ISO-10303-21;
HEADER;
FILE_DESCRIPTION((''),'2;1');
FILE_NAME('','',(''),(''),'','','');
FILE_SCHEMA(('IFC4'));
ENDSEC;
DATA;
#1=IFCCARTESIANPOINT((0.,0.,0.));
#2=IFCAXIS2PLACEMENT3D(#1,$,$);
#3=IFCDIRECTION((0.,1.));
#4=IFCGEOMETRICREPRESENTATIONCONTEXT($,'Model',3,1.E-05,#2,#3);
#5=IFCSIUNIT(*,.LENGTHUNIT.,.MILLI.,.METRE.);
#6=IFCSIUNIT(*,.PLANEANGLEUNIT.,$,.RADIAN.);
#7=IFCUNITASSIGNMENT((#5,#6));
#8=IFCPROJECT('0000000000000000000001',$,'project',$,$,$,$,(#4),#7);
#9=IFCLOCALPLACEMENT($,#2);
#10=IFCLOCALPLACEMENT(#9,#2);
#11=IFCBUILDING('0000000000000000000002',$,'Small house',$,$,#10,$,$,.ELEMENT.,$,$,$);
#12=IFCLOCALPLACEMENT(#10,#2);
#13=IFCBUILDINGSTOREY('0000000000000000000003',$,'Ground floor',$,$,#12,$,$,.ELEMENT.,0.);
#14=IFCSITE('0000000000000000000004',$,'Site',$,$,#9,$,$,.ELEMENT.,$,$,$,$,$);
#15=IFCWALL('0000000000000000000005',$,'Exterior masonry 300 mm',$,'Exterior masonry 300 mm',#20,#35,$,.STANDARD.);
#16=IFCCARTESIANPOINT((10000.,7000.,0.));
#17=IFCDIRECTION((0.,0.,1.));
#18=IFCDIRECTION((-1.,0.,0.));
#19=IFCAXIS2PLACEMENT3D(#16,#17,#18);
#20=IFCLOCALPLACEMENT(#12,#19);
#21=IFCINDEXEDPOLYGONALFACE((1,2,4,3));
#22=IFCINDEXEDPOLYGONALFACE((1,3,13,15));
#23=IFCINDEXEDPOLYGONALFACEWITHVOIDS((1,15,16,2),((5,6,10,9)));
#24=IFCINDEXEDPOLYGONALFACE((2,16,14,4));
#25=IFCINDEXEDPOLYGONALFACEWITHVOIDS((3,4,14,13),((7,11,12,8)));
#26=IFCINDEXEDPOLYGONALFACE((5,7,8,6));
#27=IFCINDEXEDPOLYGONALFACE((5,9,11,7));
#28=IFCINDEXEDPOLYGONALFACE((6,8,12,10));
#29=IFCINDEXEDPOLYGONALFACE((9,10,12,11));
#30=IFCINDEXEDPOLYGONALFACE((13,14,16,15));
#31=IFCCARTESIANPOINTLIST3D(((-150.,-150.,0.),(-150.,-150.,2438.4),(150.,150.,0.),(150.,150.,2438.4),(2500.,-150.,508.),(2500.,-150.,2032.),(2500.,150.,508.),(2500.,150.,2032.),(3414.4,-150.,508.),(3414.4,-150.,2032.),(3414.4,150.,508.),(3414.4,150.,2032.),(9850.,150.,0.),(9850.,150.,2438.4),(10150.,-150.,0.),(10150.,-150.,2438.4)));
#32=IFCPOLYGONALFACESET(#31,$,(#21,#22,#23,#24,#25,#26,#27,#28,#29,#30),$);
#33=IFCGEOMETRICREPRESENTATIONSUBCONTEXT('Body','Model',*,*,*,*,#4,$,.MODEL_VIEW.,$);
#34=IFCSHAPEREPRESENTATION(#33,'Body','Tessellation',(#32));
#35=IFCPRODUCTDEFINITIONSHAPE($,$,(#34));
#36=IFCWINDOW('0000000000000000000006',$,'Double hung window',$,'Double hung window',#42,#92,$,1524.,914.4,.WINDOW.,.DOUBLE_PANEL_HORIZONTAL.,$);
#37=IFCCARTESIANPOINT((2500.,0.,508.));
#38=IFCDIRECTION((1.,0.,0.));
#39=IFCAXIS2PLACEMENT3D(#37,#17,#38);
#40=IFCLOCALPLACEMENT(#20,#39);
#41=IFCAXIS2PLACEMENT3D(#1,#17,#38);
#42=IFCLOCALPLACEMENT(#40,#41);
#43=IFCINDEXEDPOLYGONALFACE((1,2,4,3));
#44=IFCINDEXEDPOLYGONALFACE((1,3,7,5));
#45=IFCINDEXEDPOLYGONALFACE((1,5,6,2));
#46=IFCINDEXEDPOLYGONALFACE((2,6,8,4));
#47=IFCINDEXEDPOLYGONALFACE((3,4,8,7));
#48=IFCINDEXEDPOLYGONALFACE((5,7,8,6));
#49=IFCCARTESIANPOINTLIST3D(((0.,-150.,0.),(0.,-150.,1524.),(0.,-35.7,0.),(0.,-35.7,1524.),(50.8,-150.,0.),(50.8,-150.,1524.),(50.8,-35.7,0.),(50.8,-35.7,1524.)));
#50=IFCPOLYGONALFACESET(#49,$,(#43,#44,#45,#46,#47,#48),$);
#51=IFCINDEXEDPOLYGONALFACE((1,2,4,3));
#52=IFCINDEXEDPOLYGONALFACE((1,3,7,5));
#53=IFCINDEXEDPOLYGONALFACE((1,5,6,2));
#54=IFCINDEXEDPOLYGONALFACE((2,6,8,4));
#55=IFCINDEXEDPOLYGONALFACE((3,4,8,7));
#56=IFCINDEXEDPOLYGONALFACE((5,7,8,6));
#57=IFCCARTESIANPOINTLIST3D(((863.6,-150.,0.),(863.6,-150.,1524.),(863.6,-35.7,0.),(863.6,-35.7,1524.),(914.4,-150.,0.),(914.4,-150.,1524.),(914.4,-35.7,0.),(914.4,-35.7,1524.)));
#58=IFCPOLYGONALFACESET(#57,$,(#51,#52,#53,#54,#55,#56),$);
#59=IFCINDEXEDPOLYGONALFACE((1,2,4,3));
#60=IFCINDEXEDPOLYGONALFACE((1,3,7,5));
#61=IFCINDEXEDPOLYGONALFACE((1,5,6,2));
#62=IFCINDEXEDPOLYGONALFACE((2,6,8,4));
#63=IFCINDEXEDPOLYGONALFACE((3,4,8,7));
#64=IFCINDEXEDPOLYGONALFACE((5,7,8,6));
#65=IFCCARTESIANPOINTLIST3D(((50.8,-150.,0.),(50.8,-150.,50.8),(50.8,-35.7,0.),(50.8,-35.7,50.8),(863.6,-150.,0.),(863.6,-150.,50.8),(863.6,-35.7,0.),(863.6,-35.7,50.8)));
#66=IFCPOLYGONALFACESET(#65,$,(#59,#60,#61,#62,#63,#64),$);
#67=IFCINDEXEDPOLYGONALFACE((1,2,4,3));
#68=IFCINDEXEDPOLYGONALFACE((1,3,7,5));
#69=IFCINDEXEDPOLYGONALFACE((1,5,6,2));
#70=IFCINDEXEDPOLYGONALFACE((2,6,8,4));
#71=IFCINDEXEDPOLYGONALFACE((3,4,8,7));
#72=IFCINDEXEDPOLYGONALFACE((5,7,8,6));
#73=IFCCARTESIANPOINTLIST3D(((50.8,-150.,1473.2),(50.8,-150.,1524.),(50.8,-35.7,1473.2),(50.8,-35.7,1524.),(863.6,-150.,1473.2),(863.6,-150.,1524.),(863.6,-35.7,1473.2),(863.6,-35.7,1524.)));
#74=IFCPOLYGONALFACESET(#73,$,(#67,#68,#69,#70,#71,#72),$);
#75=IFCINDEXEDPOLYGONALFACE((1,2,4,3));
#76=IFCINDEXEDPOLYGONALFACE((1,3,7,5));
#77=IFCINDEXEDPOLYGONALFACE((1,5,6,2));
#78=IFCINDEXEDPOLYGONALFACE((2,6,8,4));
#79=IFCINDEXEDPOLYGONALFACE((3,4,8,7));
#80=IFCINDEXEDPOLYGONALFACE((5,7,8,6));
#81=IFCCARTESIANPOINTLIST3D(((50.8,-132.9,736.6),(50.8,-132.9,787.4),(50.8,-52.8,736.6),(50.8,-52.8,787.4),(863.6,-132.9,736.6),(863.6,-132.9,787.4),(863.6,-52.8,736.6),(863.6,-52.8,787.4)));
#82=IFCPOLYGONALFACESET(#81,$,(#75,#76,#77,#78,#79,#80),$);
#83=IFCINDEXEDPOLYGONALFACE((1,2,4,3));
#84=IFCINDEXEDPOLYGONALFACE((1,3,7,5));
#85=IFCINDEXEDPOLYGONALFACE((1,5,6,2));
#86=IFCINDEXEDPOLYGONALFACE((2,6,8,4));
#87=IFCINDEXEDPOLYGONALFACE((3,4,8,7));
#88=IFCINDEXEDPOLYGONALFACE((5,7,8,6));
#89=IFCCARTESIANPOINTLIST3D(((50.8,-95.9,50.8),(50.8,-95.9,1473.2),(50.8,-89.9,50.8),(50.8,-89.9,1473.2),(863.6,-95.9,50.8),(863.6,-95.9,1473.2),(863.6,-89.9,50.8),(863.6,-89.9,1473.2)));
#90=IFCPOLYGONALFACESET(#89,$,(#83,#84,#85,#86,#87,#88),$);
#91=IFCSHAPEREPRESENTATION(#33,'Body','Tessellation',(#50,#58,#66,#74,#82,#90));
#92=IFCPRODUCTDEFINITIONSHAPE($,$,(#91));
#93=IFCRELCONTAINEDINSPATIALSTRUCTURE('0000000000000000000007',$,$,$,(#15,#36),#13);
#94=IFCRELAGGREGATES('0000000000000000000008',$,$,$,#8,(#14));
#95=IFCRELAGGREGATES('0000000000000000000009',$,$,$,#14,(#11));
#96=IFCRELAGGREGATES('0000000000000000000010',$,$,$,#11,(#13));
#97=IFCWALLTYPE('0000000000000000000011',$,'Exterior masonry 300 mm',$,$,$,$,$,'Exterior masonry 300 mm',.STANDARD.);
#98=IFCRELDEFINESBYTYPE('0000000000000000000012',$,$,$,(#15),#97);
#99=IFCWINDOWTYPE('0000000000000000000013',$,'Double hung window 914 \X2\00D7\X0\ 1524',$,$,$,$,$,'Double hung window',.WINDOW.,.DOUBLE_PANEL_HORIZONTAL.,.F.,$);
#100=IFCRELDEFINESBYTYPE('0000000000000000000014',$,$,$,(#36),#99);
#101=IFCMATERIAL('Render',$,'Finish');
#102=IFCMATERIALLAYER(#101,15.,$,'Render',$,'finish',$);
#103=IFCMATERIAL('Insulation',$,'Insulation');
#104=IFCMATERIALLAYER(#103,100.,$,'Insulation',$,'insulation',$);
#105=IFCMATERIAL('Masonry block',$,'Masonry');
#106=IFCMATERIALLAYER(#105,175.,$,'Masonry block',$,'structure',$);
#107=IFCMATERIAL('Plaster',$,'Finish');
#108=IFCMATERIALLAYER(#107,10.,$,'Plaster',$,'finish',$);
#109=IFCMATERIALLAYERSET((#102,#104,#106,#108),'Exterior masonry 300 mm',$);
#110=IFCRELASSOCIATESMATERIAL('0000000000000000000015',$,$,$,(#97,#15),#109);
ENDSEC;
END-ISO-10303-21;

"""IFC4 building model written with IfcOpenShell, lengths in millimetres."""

from ifc_helpers import new_model, si_unit, direction, frame, origin, origin_with_axes, place, context, subcontext, project, spatial, polyline, outline, extrude, material, layer, layer_set, layer_usage, type_object, element, fill, save


model = new_model("IFC4")

# Units and contexts
model_context = context("Model", 3, precision=1e-05, world=origin(), true_north=direction((0.0, 1.0)))
body_context = subcontext(model_context, "Body", "Model", "MODEL_VIEW")
ifc_project = project(units=[si_unit("LENGTHUNIT", "METRE", prefix="MILLI"), si_unit("PLANEANGLEUNIT", "RADIAN")], contexts=[model_context])

# Site, building, storey
site_placement = place(None, origin())
site = spatial("IfcSite", under=ifc_project, at=site_placement, Name="Site", CompositionType="ELEMENT")
building_placement = place(site_placement, origin())
building = spatial("IfcBuilding", under=site, at=building_placement, Name="Small house", CompositionType="ELEMENT")
storey_placement = place(building_placement, origin())
storey = spatial("IfcBuildingStorey", under=building, at=storey_placement, Name="Ground floor", CompositionType="ELEMENT", Elevation=0.0)

# Shared definitions
ifc_material_1 = material(Name="Render", Category="Finish")
ifc_layer_1 = layer(ifc_material_1, 15.0, Name="Render", Category="finish")
ifc_material_2 = material(Name="Insulation", Category="Insulation")
ifc_layer_2 = layer(ifc_material_2, 100.0, Name="Insulation", Category="insulation")
ifc_material_3 = material(Name="Masonry block", Category="Masonry")
ifc_layer_3 = layer(ifc_material_3, 175.0, Name="Masonry block", Category="structure")
ifc_material_4 = material(Name="Plaster", Category="Finish")
ifc_layer_4 = layer(ifc_material_4, 10.0, Name="Plaster", Category="finish")
ifc_layer_set_1 = layer_set([ifc_layer_1, ifc_layer_2, ifc_layer_3, ifc_layer_4], Name="Exterior masonry 300 mm")
wall_type_1 = type_object("IfcWallType", Name="Exterior masonry 300 mm", ElementType="Exterior masonry 300 mm", PredefinedType="STANDARD", material=ifc_layer_set_1)
window_type = type_object("IfcWindowType", Name="Double hung window 914 × 1524", ElementType="Double hung window", ParameterTakesPrecedence=False, PartitioningType="DOUBLE_PANEL_HORIZONTAL", PredefinedType="WINDOW")

# Wall, opening, window
ifc_layer_usage_1 = layer_usage(ifc_layer_set_1, "AXIS2", "POSITIVE", -150.0)
wall_1_placement = place(storey_placement, frame((10000.0, 7000.0, 0.0), z_axis=(0.0, 0.0, 1.0), x_axis=(-1.0, 0.0, 0.0)))
wall_1 = element("IfcWall", 1, at=wall_1_placement, inside=storey, type_object=wall_type_1, material=ifc_layer_usage_1, Name="Exterior masonry 300 mm", ObjectType="Exterior masonry 300 mm", PredefinedType="STANDARD", context=body_context, shape_type="SweptSolid", body=[
    extrude(outline(polyline([(-150.0, -150.0), (10150.0, -150.0), (9850.0, 150.0), (150.0, 150.0), (-150.0, -150.0)])), origin(), (0.0, 0.0, 1.0), 2438.4),
])
opening_1_placement = place(wall_1_placement, frame((2500.0, 0.0, 508.0), z_axis=(0.0, 0.0, 1.0), x_axis=(1.0, 0.0, 0.0)))
opening_1 = element("IfcOpeningElement", 2, at=opening_1_placement, cuts=wall_1, PredefinedType="OPENING", context=body_context, shape_type="SweptSolid", body=[
    extrude(outline(polyline([(0.0, -160.0), (914.4, -160.0), (914.4, 160.0), (0.0, 160.0), (0.0, -160.0)])), origin(), (0.0, 0.0, 1.0), 1524.0),
])
window_1_placement = place(opening_1_placement, origin_with_axes())
window_1 = element("IfcWindow", 3, at=window_1_placement, inside=storey, type_object=window_type, Name="Double hung window", ObjectType="Double hung window", OverallHeight=1524.0, OverallWidth=914.4, PartitioningType="DOUBLE_PANEL_HORIZONTAL", PredefinedType="WINDOW", context=body_context, shape_type="SweptSolid", body=[
    extrude(outline(polyline([(0.0, -150.0), (50.8, -150.0), (50.8, -35.7), (0.0, -35.7), (0.0, -150.0)])), origin(), (0.0, 0.0, 1.0), 1524.0),
    extrude(outline(polyline([(863.6, -150.0), (914.4, -150.0), (914.4, -35.7), (863.6, -35.7), (863.6, -150.0)])), origin(), (0.0, 0.0, 1.0), 1524.0),
    extrude(outline(polyline([(50.8, -150.0), (863.6, -150.0), (863.6, -35.7), (50.8, -35.7), (50.8, -150.0)])), origin(), (0.0, 0.0, 1.0), 50.8),
    extrude(outline(polyline([(50.8, -150.0), (863.6, -150.0), (863.6, -35.7), (50.8, -35.7), (50.8, -150.0)])), frame((0.0, 0.0, 1473.2)), (0.0, 0.0, 1.0), 50.8),
    extrude(outline(polyline([(50.8, -132.9), (863.6, -132.9), (863.6, -52.8), (50.8, -52.8), (50.8, -132.9)])), frame((0.0, 0.0, 736.6)), (0.0, 0.0, 1.0), 50.8),
    extrude(outline(polyline([(50.8, -95.8), (863.6, -95.8), (863.6, -89.8), (50.8, -89.8), (50.8, -95.8)])), frame((0.0, 0.0, 50.8)), (0.0, 0.0, 1.0), 1422.4),
])
fill(opening_1, window_1)

save(model, "model.ifc")
